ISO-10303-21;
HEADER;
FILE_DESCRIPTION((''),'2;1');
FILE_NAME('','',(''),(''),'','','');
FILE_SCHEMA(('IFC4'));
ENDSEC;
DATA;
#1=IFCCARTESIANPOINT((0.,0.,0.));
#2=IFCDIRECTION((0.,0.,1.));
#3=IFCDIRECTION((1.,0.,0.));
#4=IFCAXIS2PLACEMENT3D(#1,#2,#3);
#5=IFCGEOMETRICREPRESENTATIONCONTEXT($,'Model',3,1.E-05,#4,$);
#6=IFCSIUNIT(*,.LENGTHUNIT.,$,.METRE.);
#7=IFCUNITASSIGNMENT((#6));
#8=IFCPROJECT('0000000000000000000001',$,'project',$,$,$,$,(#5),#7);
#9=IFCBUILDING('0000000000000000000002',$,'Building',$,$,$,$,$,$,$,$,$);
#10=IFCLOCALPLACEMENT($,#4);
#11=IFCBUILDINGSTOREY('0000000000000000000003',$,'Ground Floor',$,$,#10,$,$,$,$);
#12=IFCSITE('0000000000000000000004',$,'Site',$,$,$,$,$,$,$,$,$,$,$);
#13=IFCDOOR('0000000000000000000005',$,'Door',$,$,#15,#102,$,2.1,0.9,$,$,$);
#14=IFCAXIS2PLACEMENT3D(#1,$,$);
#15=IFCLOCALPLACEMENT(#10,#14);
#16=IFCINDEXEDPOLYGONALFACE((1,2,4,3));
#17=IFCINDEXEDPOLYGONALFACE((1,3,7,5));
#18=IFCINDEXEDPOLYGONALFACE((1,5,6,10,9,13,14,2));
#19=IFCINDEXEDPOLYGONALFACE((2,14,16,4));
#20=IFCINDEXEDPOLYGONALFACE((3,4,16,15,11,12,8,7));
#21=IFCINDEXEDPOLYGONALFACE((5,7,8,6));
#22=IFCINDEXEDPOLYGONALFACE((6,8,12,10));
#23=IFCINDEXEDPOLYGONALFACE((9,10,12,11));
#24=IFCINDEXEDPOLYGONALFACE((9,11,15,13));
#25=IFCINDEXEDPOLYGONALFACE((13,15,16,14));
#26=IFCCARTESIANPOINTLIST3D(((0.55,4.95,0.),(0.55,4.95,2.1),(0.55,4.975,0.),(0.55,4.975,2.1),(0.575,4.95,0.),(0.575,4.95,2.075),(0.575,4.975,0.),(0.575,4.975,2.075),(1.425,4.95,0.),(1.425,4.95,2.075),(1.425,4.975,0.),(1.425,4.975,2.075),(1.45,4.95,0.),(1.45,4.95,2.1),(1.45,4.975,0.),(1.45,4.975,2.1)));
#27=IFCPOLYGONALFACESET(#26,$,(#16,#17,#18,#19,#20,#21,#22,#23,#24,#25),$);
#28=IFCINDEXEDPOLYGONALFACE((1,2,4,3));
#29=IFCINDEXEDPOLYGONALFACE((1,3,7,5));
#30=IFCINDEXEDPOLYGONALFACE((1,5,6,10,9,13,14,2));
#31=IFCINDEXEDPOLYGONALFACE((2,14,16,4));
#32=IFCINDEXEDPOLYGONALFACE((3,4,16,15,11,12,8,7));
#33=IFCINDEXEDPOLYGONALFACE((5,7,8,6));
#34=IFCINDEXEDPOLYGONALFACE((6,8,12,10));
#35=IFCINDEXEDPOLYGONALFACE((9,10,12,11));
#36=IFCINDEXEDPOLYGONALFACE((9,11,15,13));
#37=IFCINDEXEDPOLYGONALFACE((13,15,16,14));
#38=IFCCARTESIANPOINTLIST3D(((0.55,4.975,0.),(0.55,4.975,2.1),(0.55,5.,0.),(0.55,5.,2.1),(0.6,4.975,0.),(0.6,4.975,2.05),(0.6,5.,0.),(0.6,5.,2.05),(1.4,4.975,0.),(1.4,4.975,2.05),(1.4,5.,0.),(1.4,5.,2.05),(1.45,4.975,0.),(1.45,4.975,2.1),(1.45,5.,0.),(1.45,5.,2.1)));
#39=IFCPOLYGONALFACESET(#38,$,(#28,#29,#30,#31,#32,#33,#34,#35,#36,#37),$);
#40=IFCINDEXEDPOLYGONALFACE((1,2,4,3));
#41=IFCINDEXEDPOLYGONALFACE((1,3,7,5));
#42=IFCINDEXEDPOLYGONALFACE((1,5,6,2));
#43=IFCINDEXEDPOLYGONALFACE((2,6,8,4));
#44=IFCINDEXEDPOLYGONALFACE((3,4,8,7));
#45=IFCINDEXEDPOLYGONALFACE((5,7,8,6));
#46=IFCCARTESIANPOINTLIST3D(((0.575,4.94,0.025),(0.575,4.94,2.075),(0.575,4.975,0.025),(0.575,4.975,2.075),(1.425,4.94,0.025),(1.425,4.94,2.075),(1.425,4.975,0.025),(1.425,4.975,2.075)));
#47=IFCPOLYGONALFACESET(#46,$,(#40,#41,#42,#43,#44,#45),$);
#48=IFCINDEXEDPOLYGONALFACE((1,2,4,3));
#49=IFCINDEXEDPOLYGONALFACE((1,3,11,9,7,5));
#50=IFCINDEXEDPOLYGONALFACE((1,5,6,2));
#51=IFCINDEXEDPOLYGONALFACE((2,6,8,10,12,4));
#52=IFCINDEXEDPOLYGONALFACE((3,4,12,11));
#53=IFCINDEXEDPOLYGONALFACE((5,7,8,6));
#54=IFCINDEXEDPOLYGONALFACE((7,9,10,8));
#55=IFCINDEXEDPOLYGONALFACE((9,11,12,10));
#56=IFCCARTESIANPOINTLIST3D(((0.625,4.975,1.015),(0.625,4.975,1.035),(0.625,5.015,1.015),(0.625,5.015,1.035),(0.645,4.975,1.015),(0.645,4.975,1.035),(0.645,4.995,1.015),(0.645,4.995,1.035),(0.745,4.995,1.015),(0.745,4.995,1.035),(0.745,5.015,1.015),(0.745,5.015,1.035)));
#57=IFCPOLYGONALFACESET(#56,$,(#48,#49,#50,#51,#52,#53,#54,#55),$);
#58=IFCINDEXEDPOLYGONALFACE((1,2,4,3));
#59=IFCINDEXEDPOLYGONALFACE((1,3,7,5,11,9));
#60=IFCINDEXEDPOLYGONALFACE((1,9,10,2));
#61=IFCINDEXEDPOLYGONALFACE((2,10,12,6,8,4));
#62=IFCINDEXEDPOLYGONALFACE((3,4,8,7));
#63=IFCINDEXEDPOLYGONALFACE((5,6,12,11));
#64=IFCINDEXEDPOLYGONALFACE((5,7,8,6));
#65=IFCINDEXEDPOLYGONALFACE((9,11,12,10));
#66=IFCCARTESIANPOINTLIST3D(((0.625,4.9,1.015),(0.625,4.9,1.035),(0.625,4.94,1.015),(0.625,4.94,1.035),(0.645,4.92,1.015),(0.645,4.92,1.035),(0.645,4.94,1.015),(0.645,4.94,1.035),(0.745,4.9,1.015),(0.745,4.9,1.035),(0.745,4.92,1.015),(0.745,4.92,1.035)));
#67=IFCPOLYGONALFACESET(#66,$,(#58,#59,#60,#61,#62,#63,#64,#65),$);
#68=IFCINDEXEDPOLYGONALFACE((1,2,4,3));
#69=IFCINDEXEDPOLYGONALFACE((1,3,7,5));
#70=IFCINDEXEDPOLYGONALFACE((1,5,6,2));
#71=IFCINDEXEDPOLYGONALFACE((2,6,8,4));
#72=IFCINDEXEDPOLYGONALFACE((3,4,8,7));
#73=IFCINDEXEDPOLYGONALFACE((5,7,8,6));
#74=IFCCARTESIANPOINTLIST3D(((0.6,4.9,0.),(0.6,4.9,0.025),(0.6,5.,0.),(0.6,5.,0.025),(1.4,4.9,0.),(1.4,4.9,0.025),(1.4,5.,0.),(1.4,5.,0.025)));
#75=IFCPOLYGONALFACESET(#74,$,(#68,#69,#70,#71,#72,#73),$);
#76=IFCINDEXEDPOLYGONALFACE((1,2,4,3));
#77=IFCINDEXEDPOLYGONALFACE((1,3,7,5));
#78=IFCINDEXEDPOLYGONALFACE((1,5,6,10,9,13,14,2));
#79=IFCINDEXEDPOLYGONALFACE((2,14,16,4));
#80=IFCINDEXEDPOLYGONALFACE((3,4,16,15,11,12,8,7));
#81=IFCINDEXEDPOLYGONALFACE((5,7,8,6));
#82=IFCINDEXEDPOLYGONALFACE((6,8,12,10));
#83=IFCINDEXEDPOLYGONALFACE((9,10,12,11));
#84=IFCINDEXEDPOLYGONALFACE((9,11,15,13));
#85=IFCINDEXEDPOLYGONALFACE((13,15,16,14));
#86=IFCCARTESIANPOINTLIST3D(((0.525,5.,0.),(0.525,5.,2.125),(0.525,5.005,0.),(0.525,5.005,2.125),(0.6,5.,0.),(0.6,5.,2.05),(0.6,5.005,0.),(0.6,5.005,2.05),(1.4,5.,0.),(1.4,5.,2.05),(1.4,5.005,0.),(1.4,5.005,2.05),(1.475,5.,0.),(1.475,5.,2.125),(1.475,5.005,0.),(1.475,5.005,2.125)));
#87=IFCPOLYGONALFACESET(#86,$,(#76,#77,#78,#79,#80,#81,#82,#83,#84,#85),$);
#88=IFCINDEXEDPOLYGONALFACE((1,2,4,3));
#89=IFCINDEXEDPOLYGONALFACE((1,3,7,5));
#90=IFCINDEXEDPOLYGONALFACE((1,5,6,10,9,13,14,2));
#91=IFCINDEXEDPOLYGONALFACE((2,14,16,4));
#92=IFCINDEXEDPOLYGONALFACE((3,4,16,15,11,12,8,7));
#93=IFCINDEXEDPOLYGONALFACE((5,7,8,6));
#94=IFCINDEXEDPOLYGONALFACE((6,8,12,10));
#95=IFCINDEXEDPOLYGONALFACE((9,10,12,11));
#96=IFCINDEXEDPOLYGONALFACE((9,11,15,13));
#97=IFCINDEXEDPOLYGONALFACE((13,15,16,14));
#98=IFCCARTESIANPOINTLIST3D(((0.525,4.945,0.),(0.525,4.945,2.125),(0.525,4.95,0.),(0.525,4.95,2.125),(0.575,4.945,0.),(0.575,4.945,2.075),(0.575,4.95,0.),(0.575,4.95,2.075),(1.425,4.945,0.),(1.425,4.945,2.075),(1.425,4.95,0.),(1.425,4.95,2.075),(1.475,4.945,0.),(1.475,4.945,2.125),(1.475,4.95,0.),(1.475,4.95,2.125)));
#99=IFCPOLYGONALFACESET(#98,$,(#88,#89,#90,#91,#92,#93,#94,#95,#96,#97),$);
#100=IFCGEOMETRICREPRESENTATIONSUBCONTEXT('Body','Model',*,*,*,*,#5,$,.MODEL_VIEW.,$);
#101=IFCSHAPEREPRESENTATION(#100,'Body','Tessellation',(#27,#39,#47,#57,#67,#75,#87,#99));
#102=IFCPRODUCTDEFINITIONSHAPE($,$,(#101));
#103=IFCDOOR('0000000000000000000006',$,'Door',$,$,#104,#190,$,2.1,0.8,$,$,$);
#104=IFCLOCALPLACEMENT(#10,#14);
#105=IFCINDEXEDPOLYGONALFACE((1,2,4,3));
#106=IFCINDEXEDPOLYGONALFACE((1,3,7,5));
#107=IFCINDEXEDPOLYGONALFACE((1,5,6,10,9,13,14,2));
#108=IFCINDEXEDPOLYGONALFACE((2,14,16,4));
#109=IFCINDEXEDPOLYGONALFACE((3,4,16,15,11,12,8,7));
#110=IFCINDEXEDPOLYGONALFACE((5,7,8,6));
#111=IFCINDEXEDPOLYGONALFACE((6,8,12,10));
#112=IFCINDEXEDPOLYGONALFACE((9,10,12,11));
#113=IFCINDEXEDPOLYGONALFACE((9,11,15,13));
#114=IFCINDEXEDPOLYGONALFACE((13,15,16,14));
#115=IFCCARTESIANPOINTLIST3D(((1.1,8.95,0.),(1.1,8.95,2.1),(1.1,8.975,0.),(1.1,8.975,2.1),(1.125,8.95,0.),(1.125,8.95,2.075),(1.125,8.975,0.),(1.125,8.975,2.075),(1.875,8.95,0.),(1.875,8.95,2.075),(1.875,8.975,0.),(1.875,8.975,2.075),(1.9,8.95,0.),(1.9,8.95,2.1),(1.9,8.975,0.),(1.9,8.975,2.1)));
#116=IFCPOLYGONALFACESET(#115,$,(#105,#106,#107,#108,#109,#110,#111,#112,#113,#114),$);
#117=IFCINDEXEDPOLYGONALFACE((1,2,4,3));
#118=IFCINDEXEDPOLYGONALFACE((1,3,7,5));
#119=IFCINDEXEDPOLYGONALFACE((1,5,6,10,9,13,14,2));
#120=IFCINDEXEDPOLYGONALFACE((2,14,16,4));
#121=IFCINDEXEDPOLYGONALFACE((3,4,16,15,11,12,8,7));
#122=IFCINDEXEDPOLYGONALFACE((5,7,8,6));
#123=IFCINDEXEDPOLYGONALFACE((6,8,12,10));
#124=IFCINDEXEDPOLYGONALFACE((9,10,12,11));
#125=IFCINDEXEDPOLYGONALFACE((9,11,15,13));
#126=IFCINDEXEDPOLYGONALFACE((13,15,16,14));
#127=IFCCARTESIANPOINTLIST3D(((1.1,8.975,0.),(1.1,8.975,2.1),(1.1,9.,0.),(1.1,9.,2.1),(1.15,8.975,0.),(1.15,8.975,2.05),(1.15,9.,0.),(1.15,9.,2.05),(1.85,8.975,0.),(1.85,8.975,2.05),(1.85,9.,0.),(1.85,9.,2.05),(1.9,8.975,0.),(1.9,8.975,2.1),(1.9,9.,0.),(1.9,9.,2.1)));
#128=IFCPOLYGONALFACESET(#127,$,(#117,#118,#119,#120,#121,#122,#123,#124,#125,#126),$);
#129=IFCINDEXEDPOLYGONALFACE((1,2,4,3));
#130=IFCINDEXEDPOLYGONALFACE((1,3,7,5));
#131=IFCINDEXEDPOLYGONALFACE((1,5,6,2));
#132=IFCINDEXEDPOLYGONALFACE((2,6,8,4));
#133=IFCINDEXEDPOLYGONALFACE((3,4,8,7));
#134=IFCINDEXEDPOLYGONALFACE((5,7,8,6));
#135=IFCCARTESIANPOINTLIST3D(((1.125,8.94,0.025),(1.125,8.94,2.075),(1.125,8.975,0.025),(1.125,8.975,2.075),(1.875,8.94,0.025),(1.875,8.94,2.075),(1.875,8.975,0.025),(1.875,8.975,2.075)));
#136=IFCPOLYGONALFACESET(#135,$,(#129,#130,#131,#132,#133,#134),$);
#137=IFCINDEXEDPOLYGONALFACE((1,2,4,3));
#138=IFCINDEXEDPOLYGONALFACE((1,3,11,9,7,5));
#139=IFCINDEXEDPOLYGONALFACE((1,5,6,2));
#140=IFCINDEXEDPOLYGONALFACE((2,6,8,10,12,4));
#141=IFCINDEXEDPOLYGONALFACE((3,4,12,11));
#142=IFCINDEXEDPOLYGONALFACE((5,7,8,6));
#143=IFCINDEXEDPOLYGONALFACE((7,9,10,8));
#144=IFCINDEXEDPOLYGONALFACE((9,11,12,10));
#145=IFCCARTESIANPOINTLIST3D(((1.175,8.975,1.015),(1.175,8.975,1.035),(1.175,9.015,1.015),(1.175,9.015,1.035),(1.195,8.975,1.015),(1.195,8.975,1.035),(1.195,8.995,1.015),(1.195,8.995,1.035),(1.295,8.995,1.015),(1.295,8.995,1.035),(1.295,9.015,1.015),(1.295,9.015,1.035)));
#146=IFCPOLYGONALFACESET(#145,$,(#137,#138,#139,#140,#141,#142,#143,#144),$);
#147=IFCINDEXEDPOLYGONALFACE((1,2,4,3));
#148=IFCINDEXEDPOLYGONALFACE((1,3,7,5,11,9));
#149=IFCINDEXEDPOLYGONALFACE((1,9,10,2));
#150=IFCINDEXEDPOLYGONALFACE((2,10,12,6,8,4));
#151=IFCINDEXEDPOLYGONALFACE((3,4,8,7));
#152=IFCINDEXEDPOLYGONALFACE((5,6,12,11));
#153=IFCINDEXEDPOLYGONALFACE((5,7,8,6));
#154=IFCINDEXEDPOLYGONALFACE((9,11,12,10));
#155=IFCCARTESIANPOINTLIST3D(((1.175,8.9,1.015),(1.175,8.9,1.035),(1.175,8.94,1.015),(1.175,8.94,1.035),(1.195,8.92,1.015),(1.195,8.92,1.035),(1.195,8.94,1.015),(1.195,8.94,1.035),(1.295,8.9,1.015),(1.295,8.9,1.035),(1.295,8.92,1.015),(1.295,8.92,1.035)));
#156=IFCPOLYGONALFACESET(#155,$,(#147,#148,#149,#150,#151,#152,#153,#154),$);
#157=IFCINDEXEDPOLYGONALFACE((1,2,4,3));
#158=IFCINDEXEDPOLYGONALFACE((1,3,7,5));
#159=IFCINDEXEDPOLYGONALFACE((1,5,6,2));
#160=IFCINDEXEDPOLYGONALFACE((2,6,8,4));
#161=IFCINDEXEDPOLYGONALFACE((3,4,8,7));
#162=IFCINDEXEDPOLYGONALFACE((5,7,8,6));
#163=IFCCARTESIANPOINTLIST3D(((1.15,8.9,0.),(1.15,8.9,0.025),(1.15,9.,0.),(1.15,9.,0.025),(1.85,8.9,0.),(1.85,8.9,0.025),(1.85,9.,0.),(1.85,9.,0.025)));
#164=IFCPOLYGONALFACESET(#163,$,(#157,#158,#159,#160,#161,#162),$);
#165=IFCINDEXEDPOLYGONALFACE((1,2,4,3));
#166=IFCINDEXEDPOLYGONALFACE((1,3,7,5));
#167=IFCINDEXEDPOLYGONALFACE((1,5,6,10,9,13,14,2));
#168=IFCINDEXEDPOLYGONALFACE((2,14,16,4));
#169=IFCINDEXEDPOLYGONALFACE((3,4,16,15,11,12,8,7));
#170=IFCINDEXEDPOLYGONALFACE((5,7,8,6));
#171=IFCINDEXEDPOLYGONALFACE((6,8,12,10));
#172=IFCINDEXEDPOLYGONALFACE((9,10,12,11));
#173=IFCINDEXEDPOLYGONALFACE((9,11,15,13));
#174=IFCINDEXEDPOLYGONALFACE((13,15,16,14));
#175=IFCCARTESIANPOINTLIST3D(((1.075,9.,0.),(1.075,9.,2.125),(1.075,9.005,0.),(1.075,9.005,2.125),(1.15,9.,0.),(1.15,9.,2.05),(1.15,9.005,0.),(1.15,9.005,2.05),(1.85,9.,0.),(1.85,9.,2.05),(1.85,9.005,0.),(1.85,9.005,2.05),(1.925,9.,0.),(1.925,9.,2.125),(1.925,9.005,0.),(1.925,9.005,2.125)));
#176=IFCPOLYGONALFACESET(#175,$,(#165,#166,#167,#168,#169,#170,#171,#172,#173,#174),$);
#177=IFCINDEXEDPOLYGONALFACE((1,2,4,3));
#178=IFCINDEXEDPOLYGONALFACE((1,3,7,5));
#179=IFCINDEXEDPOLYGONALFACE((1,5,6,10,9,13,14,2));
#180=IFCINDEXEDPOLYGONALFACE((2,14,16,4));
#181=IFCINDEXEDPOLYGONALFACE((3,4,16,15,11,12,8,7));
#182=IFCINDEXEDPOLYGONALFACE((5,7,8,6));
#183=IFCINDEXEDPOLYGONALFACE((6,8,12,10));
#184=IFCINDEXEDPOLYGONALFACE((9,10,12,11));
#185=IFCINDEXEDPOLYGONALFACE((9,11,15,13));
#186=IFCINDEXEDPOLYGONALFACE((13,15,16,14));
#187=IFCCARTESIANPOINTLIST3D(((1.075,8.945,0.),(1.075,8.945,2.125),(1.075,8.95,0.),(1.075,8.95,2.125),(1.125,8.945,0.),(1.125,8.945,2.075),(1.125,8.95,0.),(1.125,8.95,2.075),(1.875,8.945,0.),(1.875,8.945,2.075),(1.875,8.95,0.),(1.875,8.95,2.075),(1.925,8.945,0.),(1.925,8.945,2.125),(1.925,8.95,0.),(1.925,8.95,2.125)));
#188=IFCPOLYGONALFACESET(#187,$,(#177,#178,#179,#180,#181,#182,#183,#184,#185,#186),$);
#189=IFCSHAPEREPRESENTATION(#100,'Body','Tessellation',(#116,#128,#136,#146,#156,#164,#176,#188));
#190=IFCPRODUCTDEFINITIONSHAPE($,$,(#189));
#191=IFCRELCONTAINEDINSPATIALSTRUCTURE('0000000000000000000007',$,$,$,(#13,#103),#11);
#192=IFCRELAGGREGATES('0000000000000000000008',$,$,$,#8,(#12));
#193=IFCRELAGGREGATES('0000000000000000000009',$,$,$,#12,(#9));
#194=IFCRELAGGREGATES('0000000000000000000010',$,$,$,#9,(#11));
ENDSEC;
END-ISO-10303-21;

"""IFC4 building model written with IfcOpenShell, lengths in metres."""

from ifc_helpers import new_model, si_unit, frame, origin_with_axes, place, context, subcontext, project, spatial, line, indexed_curve, outline, extrude, element, save


model = new_model("IFC4")

# Units and contexts
model_context = context("Model", 3, precision=1e-05, world=origin_with_axes())
body_context = subcontext(model_context, "Body", "Model", "MODEL_VIEW")
ifc_project = project(units=[si_unit("LENGTHUNIT", "METRE")], contexts=[model_context])

# Site, building, storey
site = spatial("IfcSite", under=ifc_project, Name="Site")
building = spatial("IfcBuilding", under=site, Name="Building")
storey_placement = place(None, origin_with_axes())
storey = spatial("IfcBuildingStorey", under=building, at=storey_placement, Name="Ground Floor")

# Doors
door_1_placement = place(storey_placement, frame((1.45, 5.0, 0.0), z_axis=(0.0, 0.0, 1.0), x_axis=(-1.0, 0.0, 0.0)))
element("IfcDoor", 1, at=door_1_placement, inside=storey, Name="Door", OverallHeight=2.1, OverallWidth=0.9, context=body_context, shape_type="SweptSolid", body=[
    extrude(outline(indexed_curve([(0.0, 0.0), (0.0, 2.1), (0.9, 2.1), (0.9, 0.0), (0.875, 0.0), (0.875, 2.075), (0.025, 2.075), (0.025, 0.0)], segments=[line(1, 2, 3, 4, 5, 6, 7, 8, 1)])), frame((0.0, 0.025, 0.0), z_axis=(0.0, -1.0, 0.0), x_axis=(1.0, 0.0, 0.0)), (0.0, 0.0, -1.0), 0.025),
    extrude(outline(indexed_curve([(0.0, 0.0), (0.0, 2.1), (0.9, 2.1), (0.9, 0.0), (0.85, 0.0), (0.85, 2.05), (0.05, 2.05), (0.05, 0.0)], segments=[line(1, 2, 3, 4, 5, 6, 7, 8, 1)])), frame((0.0, 0.0, 0.0), z_axis=(0.0, -1.0, 0.0), x_axis=(1.0, 0.0, 0.0)), (0.0, 0.0, -1.0), 0.025),
    extrude(outline(indexed_curve([(0.0, 0.0), (0.85, 0.0), (0.85, 0.035), (0.0, 0.035)], segments=[line(1, 2, 3, 4, 1)])), frame((0.025, 0.025, 0.025), z_axis=(0.0, 0.0, 1.0), x_axis=(1.0, 0.0, 0.0)), (0.0, 0.0, 1.0), 2.05),
    extrude(outline(indexed_curve([(0.0, 0.0), (0.0, -0.04), (-0.12, -0.04), (-0.12, -0.02), (-0.02, -0.02), (-0.02, 0.0)], segments=[line(1, 2, 3, 4, 5, 6, 1)])), frame((0.825, 0.025, 1.015), z_axis=(0.0, 0.0, 1.0), x_axis=(1.0, 0.0, 0.0)), (0.0, 0.0, 1.0), 0.02),
    extrude(outline(indexed_curve([(0.0, 0.0), (0.0, 0.04), (-0.12, 0.04), (-0.12, 0.02), (-0.02, 0.02), (-0.02, 0.0)], segments=[line(1, 2, 3, 4, 5, 6, 1)])), frame((0.825, 0.06, 1.015), z_axis=(0.0, 0.0, 1.0), x_axis=(1.0, 0.0, 0.0)), (0.0, 0.0, 1.0), 0.02),
    extrude(outline(indexed_curve([(0.0, 0.0), (0.8, 0.0), (0.8, 0.1), (0.0, 0.1)], segments=[line(1, 2, 3, 4, 1)])), frame((0.05, 0.0, 0.0), z_axis=(0.0, 0.0, 1.0), x_axis=(1.0, 0.0, 0.0)), (0.0, 0.0, 1.0), 0.025),
    extrude(outline(indexed_curve([(0.0, 0.0), (0.0, 2.125), (0.95, 2.125), (0.95, 0.0), (0.875, 0.0), (0.875, 2.05), (0.075, 2.05), (0.075, 0.0)], segments=[line(1, 2, 3, 4, 5, 6, 7, 8, 1)])), frame((-0.025, -0.005, 0.0), z_axis=(0.0, -1.0, 0.0), x_axis=(1.0, 0.0, 0.0)), (0.0, 0.0, -1.0), 0.005),
    extrude(outline(indexed_curve([(0.0, 0.0), (0.0, 2.125), (0.95, 2.125), (0.95, 0.0), (0.9, 0.0), (0.9, 2.075), (0.05, 2.075), (0.05, 0.0)], segments=[line(1, 2, 3, 4, 5, 6, 7, 8, 1)])), frame((-0.025, 0.05, 0.0), z_axis=(0.0, -1.0, 0.0), x_axis=(1.0, 0.0, 0.0)), (0.0, 0.0, -1.0), 0.005),
])
door_2_placement = place(storey_placement, frame((1.9, 9.0, 0.0), z_axis=(0.0, 0.0, 1.0), x_axis=(-1.0, 0.0, 0.0)))
element("IfcDoor", 2, at=door_2_placement, inside=storey, Name="Door", OverallHeight=2.1, OverallWidth=0.8, context=body_context, shape_type="SweptSolid", body=[
    extrude(outline(indexed_curve([(0.0, 0.0), (0.0, 2.1), (0.8, 2.1), (0.8, 0.0), (0.775, 0.0), (0.775, 2.075), (0.025, 2.075), (0.025, 0.0)], segments=[line(1, 2, 3, 4, 5, 6, 7, 8, 1)])), frame((0.0, 0.025, 0.0), z_axis=(0.0, -1.0, 0.0), x_axis=(1.0, 0.0, 0.0)), (0.0, 0.0, -1.0), 0.025),
    extrude(outline(indexed_curve([(0.0, 0.0), (0.0, 2.1), (0.8, 2.1), (0.8, 0.0), (0.75, 0.0), (0.75, 2.05), (0.05, 2.05), (0.05, 0.0)], segments=[line(1, 2, 3, 4, 5, 6, 7, 8, 1)])), frame((0.0, 0.0, 0.0), z_axis=(0.0, -1.0, 0.0), x_axis=(1.0, 0.0, 0.0)), (0.0, 0.0, -1.0), 0.025),
    extrude(outline(indexed_curve([(0.0, 0.0), (0.75, 0.0), (0.75, 0.035), (0.0, 0.035)], segments=[line(1, 2, 3, 4, 1)])), frame((0.025, 0.025, 0.025), z_axis=(0.0, 0.0, 1.0), x_axis=(1.0, 0.0, 0.0)), (0.0, 0.0, 1.0), 2.05),
    extrude(outline(indexed_curve([(0.0, 0.0), (0.0, -0.04), (-0.12, -0.04), (-0.12, -0.02), (-0.02, -0.02), (-0.02, 0.0)], segments=[line(1, 2, 3, 4, 5, 6, 1)])), frame((0.725, 0.025, 1.015), z_axis=(0.0, 0.0, 1.0), x_axis=(1.0, 0.0, 0.0)), (0.0, 0.0, 1.0), 0.02),
    extrude(outline(indexed_curve([(0.0, 0.0), (0.0, 0.04), (-0.12, 0.04), (-0.12, 0.02), (-0.02, 0.02), (-0.02, 0.0)], segments=[line(1, 2, 3, 4, 5, 6, 1)])), frame((0.725, 0.06, 1.015), z_axis=(0.0, 0.0, 1.0), x_axis=(1.0, 0.0, 0.0)), (0.0, 0.0, 1.0), 0.02),
    extrude(outline(indexed_curve([(0.0, 0.0), (0.7, 0.0), (0.7, 0.1), (0.0, 0.1)], segments=[line(1, 2, 3, 4, 1)])), frame((0.05, 0.0, 0.0), z_axis=(0.0, 0.0, 1.0), x_axis=(1.0, 0.0, 0.0)), (0.0, 0.0, 1.0), 0.025),
    extrude(outline(indexed_curve([(0.0, 0.0), (0.0, 2.125), (0.85, 2.125), (0.85, 0.0), (0.775, 0.0), (0.775, 2.05), (0.075, 2.05), (0.075, 0.0)], segments=[line(1, 2, 3, 4, 5, 6, 7, 8, 1)])), frame((-0.025, -0.005, 0.0), z_axis=(0.0, -1.0, 0.0), x_axis=(1.0, 0.0, 0.0)), (0.0, 0.0, -1.0), 0.005),
    extrude(outline(indexed_curve([(0.0, 0.0), (0.0, 2.125), (0.85, 2.125), (0.85, 0.0), (0.8, 0.0), (0.8, 2.075), (0.05, 2.075), (0.05, 0.0)], segments=[line(1, 2, 3, 4, 5, 6, 7, 8, 1)])), frame((-0.025, 0.05, 0.0), z_axis=(0.0, -1.0, 0.0), x_axis=(1.0, 0.0, 0.0)), (0.0, 0.0, -1.0), 0.005),
])

save(model, "model.ifc")
